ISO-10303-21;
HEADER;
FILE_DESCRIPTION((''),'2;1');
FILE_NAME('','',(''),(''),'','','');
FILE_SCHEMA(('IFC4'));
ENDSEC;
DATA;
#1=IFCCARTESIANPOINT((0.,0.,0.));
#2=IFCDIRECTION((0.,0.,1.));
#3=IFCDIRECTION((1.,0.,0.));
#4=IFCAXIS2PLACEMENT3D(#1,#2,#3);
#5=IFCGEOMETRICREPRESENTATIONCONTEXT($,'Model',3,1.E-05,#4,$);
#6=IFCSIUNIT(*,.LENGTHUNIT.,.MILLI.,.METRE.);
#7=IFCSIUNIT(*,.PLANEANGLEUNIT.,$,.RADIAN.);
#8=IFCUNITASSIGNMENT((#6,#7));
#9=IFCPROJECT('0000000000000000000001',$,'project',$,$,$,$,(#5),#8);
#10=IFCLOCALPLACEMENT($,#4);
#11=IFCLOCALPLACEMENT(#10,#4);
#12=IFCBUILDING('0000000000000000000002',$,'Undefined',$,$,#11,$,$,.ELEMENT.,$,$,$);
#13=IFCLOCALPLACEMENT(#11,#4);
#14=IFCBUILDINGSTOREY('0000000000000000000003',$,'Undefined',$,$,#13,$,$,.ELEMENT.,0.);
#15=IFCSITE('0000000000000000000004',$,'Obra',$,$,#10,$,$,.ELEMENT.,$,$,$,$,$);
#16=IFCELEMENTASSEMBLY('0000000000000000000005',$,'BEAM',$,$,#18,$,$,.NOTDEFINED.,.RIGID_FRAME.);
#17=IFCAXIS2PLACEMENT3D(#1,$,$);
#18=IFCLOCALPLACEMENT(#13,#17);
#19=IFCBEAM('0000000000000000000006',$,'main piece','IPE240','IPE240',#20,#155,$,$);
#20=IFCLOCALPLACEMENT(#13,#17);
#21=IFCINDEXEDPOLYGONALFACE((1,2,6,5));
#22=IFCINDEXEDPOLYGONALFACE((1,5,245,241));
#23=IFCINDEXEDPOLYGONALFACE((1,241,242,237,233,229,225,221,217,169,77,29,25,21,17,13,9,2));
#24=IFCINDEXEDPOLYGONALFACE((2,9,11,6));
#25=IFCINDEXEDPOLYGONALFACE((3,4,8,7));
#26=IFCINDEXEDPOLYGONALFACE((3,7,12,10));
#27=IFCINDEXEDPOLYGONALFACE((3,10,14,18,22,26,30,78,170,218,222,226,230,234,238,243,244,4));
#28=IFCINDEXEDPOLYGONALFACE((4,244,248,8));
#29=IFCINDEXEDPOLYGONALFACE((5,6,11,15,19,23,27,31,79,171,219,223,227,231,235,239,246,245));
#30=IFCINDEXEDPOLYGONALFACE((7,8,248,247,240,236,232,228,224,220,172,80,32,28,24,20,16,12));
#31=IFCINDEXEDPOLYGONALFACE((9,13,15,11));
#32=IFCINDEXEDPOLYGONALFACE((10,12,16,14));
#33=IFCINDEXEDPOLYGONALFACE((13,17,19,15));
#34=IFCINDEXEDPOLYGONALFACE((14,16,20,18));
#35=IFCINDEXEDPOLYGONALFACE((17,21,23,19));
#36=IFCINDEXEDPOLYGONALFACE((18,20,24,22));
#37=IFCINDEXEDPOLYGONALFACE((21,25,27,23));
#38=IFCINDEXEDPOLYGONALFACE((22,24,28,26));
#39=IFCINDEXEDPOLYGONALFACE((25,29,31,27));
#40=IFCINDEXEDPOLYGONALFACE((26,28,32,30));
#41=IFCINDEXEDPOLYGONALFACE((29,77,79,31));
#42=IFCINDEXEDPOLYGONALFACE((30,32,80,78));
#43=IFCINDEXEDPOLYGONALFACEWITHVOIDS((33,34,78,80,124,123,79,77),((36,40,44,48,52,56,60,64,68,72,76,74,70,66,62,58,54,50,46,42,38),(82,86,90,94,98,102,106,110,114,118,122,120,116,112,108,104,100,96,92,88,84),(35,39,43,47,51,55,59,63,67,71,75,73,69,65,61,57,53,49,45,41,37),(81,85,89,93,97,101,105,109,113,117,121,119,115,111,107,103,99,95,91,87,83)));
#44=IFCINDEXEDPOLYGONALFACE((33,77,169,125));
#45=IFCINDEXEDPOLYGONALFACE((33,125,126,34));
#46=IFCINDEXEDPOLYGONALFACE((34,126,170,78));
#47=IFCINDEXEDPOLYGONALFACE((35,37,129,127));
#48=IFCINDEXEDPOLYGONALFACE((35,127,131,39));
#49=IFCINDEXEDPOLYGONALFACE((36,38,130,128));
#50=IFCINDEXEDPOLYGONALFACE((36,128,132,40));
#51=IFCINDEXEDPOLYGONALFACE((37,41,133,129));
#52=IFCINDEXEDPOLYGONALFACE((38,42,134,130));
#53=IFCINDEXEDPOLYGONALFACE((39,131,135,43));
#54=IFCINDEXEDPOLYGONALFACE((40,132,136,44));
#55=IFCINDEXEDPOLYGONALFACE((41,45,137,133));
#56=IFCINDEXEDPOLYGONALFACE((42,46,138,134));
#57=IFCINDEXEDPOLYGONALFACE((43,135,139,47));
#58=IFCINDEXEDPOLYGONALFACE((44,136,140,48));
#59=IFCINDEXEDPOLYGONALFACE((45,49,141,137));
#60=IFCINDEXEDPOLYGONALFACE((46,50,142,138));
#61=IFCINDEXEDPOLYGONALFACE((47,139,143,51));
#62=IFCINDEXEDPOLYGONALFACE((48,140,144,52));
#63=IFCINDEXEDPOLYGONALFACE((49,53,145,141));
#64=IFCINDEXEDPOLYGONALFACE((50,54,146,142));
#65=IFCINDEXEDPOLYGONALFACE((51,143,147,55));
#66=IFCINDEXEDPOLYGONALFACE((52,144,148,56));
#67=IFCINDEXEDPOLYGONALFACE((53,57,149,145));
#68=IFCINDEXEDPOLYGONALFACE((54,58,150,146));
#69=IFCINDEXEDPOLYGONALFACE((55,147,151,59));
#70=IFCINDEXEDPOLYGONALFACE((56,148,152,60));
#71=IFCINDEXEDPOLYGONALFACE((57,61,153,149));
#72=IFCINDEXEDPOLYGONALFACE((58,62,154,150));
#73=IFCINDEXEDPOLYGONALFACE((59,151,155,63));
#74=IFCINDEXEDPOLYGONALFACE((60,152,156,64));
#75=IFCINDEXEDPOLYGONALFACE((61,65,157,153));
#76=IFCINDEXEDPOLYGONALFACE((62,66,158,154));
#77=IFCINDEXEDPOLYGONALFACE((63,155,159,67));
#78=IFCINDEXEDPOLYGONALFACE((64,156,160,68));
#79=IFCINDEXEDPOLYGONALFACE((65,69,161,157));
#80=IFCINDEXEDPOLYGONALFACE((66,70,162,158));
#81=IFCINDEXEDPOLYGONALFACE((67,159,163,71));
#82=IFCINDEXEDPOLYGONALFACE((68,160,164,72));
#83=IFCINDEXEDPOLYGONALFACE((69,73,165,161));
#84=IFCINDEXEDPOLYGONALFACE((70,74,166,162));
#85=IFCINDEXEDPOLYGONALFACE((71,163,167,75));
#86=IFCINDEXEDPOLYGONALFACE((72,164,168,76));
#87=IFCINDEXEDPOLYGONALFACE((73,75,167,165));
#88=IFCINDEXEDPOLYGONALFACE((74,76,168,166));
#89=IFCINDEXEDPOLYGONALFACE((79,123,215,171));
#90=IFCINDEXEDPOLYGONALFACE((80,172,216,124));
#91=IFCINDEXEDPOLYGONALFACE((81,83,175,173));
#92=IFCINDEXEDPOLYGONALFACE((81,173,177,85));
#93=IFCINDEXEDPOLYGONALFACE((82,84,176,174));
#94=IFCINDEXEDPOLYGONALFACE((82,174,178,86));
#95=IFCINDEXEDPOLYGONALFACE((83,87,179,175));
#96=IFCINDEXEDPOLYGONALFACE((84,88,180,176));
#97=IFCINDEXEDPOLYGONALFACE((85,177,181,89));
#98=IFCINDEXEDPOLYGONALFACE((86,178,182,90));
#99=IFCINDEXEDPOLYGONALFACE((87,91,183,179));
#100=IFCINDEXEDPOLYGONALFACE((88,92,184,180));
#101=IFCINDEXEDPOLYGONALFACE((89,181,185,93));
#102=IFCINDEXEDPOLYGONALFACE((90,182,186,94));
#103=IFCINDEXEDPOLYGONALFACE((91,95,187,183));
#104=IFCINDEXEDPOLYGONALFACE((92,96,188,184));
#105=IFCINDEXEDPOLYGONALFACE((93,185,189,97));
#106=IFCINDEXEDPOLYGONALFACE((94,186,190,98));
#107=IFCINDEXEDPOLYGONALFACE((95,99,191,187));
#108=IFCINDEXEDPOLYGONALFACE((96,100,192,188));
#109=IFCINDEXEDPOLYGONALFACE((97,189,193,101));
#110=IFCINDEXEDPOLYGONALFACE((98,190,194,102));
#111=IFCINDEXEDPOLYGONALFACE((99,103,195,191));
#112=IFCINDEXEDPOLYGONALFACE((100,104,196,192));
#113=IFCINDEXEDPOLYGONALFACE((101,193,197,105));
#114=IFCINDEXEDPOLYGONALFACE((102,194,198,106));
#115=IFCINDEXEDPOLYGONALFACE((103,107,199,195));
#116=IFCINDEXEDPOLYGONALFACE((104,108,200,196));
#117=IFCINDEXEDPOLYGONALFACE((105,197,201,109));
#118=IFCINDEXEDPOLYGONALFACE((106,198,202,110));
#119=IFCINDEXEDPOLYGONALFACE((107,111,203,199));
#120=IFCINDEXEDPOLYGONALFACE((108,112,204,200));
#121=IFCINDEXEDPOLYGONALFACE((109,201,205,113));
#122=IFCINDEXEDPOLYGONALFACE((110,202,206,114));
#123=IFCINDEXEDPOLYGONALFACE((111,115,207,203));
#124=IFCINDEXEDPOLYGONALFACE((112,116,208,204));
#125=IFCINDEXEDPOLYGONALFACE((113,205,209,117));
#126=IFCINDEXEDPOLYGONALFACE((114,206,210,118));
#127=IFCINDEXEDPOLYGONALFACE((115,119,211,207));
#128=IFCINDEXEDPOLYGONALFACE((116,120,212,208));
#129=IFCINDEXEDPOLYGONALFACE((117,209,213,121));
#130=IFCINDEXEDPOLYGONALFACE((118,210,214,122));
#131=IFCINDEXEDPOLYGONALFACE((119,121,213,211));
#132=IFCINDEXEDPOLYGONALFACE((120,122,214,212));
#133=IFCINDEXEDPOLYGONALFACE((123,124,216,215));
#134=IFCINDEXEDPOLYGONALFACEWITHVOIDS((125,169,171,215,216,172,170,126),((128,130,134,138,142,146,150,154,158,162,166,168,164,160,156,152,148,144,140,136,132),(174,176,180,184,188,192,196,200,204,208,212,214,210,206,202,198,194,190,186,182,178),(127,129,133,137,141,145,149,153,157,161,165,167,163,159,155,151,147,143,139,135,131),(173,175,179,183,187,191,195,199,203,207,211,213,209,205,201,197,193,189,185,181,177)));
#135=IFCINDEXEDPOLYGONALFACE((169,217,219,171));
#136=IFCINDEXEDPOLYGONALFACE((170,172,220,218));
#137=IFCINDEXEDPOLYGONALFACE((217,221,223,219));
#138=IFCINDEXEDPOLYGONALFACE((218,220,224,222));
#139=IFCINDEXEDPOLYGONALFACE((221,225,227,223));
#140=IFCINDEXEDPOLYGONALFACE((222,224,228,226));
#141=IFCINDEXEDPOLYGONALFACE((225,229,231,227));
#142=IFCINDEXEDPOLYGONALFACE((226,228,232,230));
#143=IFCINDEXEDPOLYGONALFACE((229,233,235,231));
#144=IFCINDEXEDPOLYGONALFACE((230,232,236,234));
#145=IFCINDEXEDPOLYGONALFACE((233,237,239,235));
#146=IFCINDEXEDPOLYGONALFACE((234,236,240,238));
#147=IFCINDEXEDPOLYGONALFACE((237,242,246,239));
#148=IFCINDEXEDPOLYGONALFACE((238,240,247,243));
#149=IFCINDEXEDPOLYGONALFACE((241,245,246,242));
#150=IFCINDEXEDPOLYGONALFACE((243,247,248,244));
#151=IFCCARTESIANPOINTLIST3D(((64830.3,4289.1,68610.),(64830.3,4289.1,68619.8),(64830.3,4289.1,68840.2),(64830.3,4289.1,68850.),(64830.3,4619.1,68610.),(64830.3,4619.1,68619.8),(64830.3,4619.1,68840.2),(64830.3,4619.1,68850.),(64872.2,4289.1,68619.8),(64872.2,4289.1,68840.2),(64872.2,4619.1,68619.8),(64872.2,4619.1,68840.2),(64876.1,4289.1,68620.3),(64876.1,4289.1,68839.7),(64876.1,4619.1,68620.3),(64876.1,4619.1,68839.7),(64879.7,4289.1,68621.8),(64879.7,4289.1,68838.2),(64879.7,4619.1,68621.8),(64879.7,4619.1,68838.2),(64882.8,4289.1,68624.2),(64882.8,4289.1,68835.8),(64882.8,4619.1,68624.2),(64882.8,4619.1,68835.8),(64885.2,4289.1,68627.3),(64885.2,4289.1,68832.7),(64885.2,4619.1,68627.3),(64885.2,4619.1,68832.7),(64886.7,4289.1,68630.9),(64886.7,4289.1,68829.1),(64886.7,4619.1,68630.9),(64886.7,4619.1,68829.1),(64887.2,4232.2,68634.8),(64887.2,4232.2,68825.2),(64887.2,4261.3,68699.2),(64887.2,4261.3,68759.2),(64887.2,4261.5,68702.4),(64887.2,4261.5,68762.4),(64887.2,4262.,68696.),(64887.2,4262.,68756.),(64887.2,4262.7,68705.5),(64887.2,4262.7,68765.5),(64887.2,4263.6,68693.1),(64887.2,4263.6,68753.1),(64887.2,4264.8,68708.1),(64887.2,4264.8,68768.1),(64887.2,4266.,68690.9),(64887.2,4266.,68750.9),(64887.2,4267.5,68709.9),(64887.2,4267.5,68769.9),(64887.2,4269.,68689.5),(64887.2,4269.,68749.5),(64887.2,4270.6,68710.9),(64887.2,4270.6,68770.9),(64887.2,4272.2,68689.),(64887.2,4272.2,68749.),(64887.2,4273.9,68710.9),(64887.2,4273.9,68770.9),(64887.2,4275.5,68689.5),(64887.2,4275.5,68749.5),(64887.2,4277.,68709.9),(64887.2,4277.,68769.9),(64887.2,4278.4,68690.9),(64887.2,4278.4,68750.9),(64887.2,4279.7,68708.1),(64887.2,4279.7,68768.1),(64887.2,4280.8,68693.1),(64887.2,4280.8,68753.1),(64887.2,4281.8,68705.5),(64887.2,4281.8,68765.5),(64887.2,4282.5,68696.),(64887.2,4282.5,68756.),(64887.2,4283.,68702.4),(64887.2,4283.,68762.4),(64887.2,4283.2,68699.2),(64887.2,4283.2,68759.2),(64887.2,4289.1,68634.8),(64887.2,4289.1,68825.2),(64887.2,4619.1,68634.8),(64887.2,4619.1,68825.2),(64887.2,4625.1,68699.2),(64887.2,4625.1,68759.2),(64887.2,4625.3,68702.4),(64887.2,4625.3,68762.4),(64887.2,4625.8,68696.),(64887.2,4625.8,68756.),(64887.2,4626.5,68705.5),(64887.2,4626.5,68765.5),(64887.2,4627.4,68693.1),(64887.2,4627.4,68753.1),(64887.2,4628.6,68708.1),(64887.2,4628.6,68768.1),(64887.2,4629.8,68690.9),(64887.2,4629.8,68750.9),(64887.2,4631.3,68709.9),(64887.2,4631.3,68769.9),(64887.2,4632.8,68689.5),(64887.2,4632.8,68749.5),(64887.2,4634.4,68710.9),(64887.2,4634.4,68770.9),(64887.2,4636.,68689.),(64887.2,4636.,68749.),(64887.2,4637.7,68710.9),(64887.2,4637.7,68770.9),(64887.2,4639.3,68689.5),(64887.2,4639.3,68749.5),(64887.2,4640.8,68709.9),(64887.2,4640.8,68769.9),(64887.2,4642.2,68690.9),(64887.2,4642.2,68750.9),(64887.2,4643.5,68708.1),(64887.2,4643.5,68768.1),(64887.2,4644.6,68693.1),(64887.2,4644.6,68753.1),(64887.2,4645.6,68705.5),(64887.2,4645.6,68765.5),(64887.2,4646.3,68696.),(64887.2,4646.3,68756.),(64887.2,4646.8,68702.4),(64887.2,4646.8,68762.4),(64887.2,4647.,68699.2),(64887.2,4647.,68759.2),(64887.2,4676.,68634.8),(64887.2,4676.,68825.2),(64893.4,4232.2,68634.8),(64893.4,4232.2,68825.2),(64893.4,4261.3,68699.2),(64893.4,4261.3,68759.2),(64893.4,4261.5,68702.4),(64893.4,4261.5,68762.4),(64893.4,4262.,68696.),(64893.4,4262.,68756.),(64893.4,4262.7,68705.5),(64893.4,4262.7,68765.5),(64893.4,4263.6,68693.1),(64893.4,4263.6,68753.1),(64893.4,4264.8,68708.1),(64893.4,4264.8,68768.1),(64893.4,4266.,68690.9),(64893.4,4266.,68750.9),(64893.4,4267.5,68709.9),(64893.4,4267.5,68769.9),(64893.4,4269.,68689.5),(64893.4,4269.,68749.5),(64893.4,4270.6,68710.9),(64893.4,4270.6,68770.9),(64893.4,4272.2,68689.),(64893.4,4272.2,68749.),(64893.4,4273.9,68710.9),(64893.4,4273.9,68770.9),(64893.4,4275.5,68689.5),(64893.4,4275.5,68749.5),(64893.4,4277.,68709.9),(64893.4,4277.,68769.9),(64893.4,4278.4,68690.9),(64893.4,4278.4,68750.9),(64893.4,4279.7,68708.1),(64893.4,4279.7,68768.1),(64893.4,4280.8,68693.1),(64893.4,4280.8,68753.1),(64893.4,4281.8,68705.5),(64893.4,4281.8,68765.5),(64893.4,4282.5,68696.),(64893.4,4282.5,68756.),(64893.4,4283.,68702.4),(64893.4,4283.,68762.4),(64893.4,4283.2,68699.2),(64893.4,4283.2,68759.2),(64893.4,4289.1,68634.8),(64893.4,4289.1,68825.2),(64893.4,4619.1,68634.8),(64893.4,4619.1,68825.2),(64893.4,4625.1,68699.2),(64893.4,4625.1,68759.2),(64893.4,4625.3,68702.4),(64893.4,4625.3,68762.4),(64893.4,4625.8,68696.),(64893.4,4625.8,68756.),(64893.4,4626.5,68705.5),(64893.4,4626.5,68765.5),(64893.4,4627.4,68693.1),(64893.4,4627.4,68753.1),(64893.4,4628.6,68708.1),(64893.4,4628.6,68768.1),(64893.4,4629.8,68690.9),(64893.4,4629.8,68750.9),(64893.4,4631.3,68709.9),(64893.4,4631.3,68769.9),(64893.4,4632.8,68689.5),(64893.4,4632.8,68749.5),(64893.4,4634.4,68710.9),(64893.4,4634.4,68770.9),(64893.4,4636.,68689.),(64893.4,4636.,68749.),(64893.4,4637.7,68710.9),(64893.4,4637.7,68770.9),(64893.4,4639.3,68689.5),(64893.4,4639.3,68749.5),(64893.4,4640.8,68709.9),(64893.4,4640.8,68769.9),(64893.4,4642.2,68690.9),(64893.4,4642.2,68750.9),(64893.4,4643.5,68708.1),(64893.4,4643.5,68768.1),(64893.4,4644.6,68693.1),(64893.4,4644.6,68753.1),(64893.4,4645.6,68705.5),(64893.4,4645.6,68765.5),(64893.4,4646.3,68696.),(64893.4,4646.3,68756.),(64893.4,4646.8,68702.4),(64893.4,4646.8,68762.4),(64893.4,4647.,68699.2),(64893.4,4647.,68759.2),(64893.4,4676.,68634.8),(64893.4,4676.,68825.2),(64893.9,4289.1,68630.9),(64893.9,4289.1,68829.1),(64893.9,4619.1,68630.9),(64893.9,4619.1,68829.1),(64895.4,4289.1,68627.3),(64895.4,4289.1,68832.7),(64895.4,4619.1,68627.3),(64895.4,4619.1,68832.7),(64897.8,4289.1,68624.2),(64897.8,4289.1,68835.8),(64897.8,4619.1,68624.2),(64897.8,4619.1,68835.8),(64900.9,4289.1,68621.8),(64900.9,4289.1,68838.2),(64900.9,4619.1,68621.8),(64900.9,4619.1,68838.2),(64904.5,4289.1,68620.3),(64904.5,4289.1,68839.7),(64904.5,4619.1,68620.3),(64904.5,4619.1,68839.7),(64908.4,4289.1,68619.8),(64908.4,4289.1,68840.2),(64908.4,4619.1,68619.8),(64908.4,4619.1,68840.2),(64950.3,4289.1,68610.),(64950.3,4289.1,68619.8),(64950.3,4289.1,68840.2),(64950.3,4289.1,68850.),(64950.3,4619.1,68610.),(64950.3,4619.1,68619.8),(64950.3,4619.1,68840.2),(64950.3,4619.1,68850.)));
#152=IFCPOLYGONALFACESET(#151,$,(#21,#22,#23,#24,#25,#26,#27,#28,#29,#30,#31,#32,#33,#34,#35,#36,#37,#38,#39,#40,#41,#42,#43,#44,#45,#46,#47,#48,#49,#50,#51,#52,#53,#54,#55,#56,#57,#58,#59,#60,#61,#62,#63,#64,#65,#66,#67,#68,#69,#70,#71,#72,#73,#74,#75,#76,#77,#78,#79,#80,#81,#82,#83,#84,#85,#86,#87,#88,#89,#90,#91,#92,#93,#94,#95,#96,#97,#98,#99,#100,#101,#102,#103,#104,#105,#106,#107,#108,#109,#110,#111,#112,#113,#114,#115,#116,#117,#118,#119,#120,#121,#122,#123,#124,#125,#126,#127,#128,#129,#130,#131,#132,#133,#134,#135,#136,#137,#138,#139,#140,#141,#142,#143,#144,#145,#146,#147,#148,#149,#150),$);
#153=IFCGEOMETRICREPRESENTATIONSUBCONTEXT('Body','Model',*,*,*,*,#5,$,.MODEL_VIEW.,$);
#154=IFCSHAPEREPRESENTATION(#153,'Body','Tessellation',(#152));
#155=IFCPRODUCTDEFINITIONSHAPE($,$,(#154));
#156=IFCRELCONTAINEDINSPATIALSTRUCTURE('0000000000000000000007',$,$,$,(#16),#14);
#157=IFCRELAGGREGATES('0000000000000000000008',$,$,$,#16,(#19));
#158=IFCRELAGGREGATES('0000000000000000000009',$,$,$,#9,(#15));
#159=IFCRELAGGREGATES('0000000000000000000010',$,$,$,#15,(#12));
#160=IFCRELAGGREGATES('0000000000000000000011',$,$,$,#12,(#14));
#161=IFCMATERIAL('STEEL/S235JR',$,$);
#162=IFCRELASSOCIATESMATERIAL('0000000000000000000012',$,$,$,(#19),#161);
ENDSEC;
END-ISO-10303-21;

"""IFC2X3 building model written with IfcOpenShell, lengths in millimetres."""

from ifc_helpers import new_model, si_unit, frame, origin_with_axes, origin_2d_with_axis, place, context, subcontext, project, spatial, rectangle, circle, i_section, extrude, clip, halfspace, source, transform, mapped, material, element, aggregate, save


model = new_model("IFC2X3")

# Units and contexts
model_context = context("Model", 3, precision=1e-05, world=origin_with_axes())
body_context = subcontext(model_context, "Body", "Model", "MODEL_VIEW")
ifc_project = project(units=[si_unit("LENGTHUNIT", "METRE", prefix="MILLI"), si_unit("PLANEANGLEUNIT", "RADIAN")], contexts=[model_context])

# Site, building, storey
site_placement = place(None, origin_with_axes())
site = spatial("IfcSite", under=ifc_project, at=site_placement, Name="Obra", CompositionType="ELEMENT")
building_placement = place(site_placement, origin_with_axes())
building = spatial("IfcBuilding", under=site, at=building_placement, Name="Undefined", CompositionType="ELEMENT")
storey_placement = place(building_placement, origin_with_axes())
storey = spatial("IfcBuildingStorey", under=building, at=storey_placement, Name="Undefined", CompositionType="ELEMENT", Elevation=0.0)

# Element assembly, beam, openings
ifc_material_1 = material(Name="STEEL/S235JR")
assembly_1_placement = place(storey_placement, origin_with_axes())
assembly_1 = element("IfcElementAssembly", 1, at=assembly_1_placement, inside=storey, Name="BEAM", AssemblyPlace="NOTDEFINED", PredefinedType="RIGID_FRAME")
beam_1_placement = place(assembly_1_placement, frame((64890.3, 4299.1, 68730.0), z_axis=(0.0, 0.0, 1.0), x_axis=(0.0, 1.0, 0.0)))
beam_1 = element("IfcBeam", 2, at=beam_1_placement, material=ifc_material_1, Name="main piece", Description="IPE240", ObjectType="IPE240", context=body_context, shape_type="Clipping", body=[
    clip(clip(extrude(i_section(OverallWidth=120.0, OverallDepth=240.0, WebThickness=6.2, FlangeThickness=9.8, FilletRadius=15.0, at=origin_2d_with_axis()), frame((376.9, 0.0, 0.0), z_axis=(-1.0, 0.0, 0.0), x_axis=(0.0, -1.0, 0.0)), (0.0, 0.0, 1.0), 443.8), halfspace(frame((376.9, 0.0, -220.0), z_axis=(-1.0, 0.0, 0.0), x_axis=(0.0, 1.0, 0.0)), True)), halfspace(frame((-66.9, 0.0, -220.0), z_axis=(1.0, 0.0, 0.0), x_axis=(0.0, -1.0, 0.0)), True)),
])
opening_1_placement = place(assembly_1_placement, frame((64890.3, 4299.1, 68730.0), z_axis=(0.0, 0.0, 1.0), x_axis=(0.0, 1.0, 0.0)))
element("IfcOpeningElement", 3, at=opening_1_placement, cuts=beam_1, ObjectType="Recess", context=body_context, shape_type="SweptSolid", body=[
    extrude(rectangle(XDim=25.8, YDim=68.9, at=origin_2d_with_axis()), frame((354.4, 61.0, -108.1), z_axis=(0.0, -1.0, 0.0), x_axis=(0.0, 0.0, -1.0)), (0.0, 0.0, 1.0), 122.0),
])
opening_2_placement = place(assembly_1_placement, frame((64890.3, 4299.1, 68730.0), z_axis=(0.0, 0.0, 1.0), x_axis=(0.0, 1.0, 0.0)))
element("IfcOpeningElement", 4, at=opening_2_placement, cuts=beam_1, ObjectType="Recess", context=body_context, shape_type="SweptSolid", body=[
    extrude(rectangle(XDim=25.8, YDim=68.9, at=origin_2d_with_axis()), frame((354.4, 61.0, 108.1), z_axis=(0.0, -1.0, 0.0), x_axis=(0.0, 0.0, -1.0)), (0.0, 0.0, 1.0), 122.0),
])
opening_3_placement = place(assembly_1_placement, frame((64890.3, 4299.1, 68730.0), z_axis=(0.0, 0.0, 1.0), x_axis=(0.0, 1.0, 0.0)))
element("IfcOpeningElement", 5, at=opening_3_placement, cuts=beam_1, ObjectType="Recess", context=body_context, shape_type="SweptSolid", body=[
    extrude(rectangle(XDim=25.8, YDim=68.9, at=origin_2d_with_axis()), frame((-44.5, -61.0, -108.1), z_axis=(0.0, 1.0, 0.0), x_axis=(0.0, 0.0, -1.0)), (0.0, 0.0, 1.0), 122.0),
])
opening_4_placement = place(assembly_1_placement, frame((64890.3, 4299.1, 68730.0), z_axis=(0.0, 0.0, 1.0), x_axis=(0.0, 1.0, 0.0)))
element("IfcOpeningElement", 6, at=opening_4_placement, cuts=beam_1, ObjectType="Recess", context=body_context, shape_type="SweptSolid", body=[
    extrude(rectangle(XDim=25.8, YDim=68.9, at=origin_2d_with_axis()), frame((-44.5, -61.0, 108.1), z_axis=(0.0, 1.0, 0.0), x_axis=(0.0, 0.0, -1.0)), (0.0, 0.0, 1.0), 122.0),
])
shared_shape_1 = source(origin_with_axes(), body_context, "Body", "SweptSolid", [
    extrude(circle(Radius=11.0, at=origin_2d_with_axis()), frame((0.0, -3.2, 0.0), z_axis=(0.0, 1.0, 0.0), x_axis=(1.0, 0.0, 0.0)), (0.0, 0.0, 1.0), 6.4),
])
opening_5_placement = place(assembly_1_placement, frame((64890.3, 4676.0, 68850.0), z_axis=(0.0, -1.0, 0.0), x_axis=(0.0, 0.0, -1.0)))
element("IfcOpeningElement", 7, at=opening_5_placement, cuts=beam_1, ObjectType="Opening", context=body_context, shape_type="MappedRepresentation", body=[
    mapped(shared_shape_1, transform((90.0, 0.0, 40.0))),
    mapped(shared_shape_1, transform((150.0, 0.0, 40.0))),
])
opening_6_placement = place(assembly_1_placement, frame((64890.3, 4232.2, 68850.0), z_axis=(0.0, 1.0, 0.0), x_axis=(0.0, 0.0, -1.0)))
element("IfcOpeningElement", 8, at=opening_6_placement, cuts=beam_1, ObjectType="Opening", context=body_context, shape_type="MappedRepresentation", body=[
    mapped(shared_shape_1, transform((90.0, 0.0, 40.0))),
    mapped(shared_shape_1, transform((150.0, 0.0, 40.0))),
])
aggregate(assembly_1, [beam_1])

save(model, "model.ifc")
